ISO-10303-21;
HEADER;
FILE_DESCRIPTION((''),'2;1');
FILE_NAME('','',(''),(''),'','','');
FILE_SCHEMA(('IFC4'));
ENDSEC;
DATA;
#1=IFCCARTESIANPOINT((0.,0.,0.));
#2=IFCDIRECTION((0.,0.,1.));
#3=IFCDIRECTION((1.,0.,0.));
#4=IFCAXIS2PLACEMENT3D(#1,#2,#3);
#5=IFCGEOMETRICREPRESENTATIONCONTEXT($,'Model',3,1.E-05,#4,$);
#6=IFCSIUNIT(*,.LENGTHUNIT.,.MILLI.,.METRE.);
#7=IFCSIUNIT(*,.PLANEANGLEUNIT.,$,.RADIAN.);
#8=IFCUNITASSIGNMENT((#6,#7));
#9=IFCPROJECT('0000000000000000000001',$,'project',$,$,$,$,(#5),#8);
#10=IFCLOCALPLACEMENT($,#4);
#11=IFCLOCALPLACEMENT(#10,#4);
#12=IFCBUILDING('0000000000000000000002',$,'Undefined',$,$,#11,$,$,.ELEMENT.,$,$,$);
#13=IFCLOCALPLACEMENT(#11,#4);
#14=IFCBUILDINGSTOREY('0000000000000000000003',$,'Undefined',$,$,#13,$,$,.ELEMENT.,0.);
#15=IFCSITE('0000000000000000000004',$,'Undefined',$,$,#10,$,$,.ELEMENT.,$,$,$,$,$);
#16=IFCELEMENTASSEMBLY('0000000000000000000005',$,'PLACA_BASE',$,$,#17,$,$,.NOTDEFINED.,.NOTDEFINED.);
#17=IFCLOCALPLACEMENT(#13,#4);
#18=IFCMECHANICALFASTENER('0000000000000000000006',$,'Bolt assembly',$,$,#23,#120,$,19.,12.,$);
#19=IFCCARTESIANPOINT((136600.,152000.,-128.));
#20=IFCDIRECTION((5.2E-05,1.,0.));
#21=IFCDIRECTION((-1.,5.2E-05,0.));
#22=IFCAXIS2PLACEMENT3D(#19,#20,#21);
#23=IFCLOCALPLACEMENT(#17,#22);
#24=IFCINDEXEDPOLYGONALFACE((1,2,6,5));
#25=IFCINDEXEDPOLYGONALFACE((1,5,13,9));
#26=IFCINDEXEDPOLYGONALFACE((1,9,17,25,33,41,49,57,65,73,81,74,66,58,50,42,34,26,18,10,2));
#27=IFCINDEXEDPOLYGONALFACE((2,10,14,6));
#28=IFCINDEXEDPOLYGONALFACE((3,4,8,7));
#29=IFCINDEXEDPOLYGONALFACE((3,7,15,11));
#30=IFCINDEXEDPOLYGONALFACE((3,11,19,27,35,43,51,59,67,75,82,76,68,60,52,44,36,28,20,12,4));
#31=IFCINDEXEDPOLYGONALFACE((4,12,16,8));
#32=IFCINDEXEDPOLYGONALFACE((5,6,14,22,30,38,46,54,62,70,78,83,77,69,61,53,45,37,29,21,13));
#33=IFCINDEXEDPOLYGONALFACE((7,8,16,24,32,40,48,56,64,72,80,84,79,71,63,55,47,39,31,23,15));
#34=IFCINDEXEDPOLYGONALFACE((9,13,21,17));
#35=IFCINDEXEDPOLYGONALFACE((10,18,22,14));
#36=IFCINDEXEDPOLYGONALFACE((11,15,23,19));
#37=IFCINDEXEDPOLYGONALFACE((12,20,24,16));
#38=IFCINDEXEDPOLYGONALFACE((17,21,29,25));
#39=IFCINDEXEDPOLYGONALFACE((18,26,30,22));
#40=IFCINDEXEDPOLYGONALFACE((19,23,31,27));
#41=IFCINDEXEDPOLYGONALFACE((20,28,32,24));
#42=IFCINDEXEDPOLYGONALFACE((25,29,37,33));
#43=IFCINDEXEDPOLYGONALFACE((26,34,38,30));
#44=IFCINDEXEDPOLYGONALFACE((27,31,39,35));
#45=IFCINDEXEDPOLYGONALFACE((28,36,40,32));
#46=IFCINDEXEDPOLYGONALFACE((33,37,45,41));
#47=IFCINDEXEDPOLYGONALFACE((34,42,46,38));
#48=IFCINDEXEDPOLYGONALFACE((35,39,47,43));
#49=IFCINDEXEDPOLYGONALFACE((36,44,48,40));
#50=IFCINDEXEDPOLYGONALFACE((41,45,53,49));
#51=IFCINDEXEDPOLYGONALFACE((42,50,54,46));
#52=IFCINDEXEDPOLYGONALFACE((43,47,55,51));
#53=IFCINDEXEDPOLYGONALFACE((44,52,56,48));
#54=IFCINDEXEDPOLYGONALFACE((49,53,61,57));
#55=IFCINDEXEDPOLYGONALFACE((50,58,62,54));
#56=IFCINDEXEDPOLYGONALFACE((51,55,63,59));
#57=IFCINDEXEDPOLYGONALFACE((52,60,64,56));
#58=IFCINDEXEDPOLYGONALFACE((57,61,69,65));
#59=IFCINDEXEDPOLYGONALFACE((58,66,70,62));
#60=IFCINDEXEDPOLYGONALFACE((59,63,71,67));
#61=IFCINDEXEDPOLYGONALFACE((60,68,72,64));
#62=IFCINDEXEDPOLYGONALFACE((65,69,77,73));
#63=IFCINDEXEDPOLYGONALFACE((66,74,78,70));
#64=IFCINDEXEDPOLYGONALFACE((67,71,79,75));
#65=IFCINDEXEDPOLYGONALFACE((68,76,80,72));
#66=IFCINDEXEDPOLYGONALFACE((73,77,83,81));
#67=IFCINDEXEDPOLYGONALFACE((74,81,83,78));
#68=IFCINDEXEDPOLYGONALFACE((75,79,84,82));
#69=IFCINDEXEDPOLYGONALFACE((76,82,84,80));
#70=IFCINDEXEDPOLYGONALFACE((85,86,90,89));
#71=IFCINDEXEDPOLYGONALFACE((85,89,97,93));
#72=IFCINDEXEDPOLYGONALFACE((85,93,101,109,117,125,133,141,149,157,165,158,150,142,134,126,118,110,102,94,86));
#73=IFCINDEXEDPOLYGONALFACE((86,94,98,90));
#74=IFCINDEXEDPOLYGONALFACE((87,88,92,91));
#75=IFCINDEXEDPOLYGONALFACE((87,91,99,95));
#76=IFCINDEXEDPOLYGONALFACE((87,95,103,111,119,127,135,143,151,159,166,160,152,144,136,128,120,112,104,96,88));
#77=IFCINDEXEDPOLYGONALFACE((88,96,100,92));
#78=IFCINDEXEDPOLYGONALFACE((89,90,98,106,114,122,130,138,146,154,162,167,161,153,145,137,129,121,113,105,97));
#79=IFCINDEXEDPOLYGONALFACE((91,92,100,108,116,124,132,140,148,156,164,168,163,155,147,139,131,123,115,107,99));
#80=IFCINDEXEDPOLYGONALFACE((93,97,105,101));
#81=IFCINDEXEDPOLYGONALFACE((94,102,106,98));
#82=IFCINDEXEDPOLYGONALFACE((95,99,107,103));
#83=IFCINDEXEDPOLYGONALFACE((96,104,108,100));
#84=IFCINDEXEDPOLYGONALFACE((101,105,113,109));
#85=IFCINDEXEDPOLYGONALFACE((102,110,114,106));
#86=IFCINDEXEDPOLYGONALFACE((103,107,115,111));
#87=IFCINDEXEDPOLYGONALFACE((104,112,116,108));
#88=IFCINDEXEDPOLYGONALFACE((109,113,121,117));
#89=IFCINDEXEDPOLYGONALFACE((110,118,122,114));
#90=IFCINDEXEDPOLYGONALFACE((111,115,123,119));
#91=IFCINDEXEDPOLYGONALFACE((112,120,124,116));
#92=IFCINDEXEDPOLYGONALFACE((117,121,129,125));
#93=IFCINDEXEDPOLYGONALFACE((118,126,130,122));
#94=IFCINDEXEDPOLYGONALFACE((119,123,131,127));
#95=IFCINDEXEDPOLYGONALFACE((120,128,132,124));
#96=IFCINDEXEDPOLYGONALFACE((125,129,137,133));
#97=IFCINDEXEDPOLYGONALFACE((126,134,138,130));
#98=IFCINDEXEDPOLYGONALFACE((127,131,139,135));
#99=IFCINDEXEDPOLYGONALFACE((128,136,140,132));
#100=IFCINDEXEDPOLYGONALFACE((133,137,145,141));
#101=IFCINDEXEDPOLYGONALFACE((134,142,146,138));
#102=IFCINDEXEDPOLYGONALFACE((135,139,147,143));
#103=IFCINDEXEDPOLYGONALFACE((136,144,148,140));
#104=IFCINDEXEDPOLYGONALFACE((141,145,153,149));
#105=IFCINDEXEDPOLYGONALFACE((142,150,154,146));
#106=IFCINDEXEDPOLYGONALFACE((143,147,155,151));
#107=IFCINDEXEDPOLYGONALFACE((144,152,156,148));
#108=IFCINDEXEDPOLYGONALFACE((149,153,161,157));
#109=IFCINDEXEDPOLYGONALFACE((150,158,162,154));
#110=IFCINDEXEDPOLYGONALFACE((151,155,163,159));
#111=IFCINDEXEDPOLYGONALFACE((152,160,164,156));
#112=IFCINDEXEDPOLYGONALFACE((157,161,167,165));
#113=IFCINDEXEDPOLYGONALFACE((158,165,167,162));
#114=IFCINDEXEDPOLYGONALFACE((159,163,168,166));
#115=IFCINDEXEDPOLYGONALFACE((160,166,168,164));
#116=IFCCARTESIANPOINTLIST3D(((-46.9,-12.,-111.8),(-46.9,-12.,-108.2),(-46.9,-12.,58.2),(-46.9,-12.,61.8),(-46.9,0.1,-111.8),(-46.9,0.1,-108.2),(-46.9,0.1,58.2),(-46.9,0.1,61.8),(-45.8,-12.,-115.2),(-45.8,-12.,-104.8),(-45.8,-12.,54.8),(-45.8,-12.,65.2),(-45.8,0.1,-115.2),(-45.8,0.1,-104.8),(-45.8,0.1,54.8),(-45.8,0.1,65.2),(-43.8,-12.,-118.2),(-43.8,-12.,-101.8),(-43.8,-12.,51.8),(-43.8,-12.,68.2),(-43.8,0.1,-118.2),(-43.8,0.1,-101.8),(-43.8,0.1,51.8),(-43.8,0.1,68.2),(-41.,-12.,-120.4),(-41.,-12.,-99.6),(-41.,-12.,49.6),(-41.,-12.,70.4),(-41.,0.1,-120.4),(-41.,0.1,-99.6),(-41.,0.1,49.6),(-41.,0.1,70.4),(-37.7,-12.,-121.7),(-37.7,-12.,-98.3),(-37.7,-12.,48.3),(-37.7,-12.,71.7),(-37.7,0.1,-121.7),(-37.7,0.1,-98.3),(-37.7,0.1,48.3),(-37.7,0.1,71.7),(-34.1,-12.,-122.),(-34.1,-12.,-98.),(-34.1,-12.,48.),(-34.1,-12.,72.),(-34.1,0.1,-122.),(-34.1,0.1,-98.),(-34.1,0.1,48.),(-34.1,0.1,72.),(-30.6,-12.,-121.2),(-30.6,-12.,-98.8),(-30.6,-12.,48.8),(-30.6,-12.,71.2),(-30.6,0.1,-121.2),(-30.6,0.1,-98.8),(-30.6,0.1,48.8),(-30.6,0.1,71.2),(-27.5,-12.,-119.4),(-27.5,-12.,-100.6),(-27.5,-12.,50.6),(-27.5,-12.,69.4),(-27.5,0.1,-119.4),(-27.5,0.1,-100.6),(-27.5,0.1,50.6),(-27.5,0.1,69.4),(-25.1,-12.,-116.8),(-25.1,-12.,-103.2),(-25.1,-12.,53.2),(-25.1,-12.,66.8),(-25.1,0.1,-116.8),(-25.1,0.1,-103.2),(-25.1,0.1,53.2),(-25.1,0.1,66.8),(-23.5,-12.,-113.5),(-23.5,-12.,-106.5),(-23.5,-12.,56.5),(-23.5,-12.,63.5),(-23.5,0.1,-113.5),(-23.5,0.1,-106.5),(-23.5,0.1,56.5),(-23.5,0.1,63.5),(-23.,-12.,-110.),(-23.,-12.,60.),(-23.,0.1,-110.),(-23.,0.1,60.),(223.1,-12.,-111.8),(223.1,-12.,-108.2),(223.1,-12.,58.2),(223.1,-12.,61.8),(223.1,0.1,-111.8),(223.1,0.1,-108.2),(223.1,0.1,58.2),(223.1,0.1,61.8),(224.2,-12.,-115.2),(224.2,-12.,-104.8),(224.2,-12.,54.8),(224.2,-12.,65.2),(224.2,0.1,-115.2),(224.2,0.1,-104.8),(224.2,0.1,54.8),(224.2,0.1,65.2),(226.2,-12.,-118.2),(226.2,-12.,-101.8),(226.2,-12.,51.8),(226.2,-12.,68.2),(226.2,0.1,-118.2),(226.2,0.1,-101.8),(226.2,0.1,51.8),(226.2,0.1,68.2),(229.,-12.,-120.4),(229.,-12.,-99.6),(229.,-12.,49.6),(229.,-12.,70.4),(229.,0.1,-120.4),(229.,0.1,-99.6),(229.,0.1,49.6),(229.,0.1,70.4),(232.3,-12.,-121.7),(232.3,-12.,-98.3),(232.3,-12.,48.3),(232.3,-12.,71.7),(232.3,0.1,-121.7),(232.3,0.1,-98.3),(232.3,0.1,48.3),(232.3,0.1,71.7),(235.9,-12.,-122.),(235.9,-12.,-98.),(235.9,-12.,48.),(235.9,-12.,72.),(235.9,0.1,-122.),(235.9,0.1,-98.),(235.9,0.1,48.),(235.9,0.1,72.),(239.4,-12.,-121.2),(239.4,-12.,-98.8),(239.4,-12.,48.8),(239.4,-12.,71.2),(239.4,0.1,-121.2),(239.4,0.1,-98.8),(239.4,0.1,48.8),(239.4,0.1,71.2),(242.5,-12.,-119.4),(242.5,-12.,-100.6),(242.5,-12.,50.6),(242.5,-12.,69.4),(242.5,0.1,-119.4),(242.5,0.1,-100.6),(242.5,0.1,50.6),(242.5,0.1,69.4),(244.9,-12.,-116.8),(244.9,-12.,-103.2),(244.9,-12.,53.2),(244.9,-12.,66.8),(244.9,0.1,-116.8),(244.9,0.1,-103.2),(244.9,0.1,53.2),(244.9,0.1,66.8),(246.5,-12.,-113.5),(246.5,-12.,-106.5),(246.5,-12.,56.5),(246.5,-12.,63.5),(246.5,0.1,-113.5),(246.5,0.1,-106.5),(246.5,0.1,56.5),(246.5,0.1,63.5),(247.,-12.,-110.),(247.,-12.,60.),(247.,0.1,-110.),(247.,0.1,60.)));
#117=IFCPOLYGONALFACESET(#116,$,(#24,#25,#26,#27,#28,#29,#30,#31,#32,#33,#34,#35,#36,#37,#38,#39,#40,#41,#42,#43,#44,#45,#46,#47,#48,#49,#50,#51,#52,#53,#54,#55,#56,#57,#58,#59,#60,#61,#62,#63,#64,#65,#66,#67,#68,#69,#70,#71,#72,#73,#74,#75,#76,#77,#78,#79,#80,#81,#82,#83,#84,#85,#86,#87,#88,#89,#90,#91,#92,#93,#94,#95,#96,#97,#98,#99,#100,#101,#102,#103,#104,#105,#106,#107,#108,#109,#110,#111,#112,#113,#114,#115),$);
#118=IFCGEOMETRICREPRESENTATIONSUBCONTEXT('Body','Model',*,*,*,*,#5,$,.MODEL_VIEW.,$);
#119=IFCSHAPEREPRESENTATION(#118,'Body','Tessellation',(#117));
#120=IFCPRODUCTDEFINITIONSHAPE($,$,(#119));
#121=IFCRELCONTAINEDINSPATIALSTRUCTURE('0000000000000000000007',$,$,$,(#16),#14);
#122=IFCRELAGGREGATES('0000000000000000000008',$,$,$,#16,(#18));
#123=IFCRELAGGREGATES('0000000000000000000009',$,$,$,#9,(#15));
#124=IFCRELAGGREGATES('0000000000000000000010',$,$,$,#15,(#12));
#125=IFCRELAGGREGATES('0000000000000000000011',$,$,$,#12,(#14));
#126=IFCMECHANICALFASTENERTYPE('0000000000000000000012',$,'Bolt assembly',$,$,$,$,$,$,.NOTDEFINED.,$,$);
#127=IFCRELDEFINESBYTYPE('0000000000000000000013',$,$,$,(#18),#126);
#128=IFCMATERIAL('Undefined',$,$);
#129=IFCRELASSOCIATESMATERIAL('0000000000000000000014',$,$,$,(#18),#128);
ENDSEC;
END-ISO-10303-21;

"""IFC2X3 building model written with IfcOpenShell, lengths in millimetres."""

from ifc_helpers import new_model, si_unit, frame, origin_with_axes, origin_2d_with_axis, place, context, subcontext, project, spatial, circle, extrude, source, transform, mapped, material, type_object, element, aggregate, save


model = new_model("IFC2X3")

# Units and contexts
model_context = context("Model", 3, precision=1e-05, world=origin_with_axes())
body_context = subcontext(model_context, "Body", "Model", "MODEL_VIEW")
ifc_project = project(units=[si_unit("LENGTHUNIT", "METRE", prefix="MILLI"), si_unit("PLANEANGLEUNIT", "RADIAN")], contexts=[model_context])

# Site, building, storey
site_placement = place(None, origin_with_axes())
site = spatial("IfcSite", under=ifc_project, at=site_placement, Name="Undefined", CompositionType="ELEMENT")
building_placement = place(site_placement, origin_with_axes())
building = spatial("IfcBuilding", under=site, at=building_placement, Name="Undefined", CompositionType="ELEMENT")
storey_placement = place(building_placement, origin_with_axes())
storey = spatial("IfcBuildingStorey", under=building, at=storey_placement, Name="Undefined", CompositionType="ELEMENT", Elevation=0.0)

# Element assembly, mechanical fastener
assembly_1_placement = place(storey_placement, origin_with_axes())
assembly_1 = element("IfcElementAssembly", 1, at=assembly_1_placement, inside=storey, Name="PLACA_BASE", AssemblyPlace="NOTDEFINED", PredefinedType="NOTDEFINED")
ifc_material_1 = material(Name="Undefined")
mechanical_fastener_type = type_object("IfcMechanicalFastenerType", Name="Bolt assembly")
shared_shape_1 = source(origin_with_axes(), body_context, "Body", "SweptSolid", [
    extrude(circle(Radius=12.0, at=origin_2d_with_axis()), frame((0.0, -12.0, 0.0), z_axis=(0.0, 1.0, 0.0), x_axis=(1.0, 0.0, 0.0)), (0.0, 0.0, 1.0), 12.1),
])
mechanical_fastener_1_placement = place(assembly_1_placement, frame((136600.0, 152000.0, -128.0), z_axis=(0.000052, 1.0, 0.0), x_axis=(-1.0, 0.000052, 0.0)))
mechanical_fastener_1 = element("IfcMechanicalFastener", 2, at=mechanical_fastener_1_placement, type_object=mechanical_fastener_type, material=ifc_material_1, Name="Bolt assembly", NominalDiameter=19.0, NominalLength=12.0, context=body_context, shape_type="MappedRepresentation", body=[
    mapped(shared_shape_1, transform((-35.0, 0.0, -110.0))),
    mapped(shared_shape_1, transform((-35.0, 0.0, 60.0))),
    mapped(shared_shape_1, transform((235.0, 0.0, -110.0))),
    mapped(shared_shape_1, transform((235.0, 0.0, 60.0))),
])
aggregate(assembly_1, [mechanical_fastener_1])

save(model, "model.ifc")
